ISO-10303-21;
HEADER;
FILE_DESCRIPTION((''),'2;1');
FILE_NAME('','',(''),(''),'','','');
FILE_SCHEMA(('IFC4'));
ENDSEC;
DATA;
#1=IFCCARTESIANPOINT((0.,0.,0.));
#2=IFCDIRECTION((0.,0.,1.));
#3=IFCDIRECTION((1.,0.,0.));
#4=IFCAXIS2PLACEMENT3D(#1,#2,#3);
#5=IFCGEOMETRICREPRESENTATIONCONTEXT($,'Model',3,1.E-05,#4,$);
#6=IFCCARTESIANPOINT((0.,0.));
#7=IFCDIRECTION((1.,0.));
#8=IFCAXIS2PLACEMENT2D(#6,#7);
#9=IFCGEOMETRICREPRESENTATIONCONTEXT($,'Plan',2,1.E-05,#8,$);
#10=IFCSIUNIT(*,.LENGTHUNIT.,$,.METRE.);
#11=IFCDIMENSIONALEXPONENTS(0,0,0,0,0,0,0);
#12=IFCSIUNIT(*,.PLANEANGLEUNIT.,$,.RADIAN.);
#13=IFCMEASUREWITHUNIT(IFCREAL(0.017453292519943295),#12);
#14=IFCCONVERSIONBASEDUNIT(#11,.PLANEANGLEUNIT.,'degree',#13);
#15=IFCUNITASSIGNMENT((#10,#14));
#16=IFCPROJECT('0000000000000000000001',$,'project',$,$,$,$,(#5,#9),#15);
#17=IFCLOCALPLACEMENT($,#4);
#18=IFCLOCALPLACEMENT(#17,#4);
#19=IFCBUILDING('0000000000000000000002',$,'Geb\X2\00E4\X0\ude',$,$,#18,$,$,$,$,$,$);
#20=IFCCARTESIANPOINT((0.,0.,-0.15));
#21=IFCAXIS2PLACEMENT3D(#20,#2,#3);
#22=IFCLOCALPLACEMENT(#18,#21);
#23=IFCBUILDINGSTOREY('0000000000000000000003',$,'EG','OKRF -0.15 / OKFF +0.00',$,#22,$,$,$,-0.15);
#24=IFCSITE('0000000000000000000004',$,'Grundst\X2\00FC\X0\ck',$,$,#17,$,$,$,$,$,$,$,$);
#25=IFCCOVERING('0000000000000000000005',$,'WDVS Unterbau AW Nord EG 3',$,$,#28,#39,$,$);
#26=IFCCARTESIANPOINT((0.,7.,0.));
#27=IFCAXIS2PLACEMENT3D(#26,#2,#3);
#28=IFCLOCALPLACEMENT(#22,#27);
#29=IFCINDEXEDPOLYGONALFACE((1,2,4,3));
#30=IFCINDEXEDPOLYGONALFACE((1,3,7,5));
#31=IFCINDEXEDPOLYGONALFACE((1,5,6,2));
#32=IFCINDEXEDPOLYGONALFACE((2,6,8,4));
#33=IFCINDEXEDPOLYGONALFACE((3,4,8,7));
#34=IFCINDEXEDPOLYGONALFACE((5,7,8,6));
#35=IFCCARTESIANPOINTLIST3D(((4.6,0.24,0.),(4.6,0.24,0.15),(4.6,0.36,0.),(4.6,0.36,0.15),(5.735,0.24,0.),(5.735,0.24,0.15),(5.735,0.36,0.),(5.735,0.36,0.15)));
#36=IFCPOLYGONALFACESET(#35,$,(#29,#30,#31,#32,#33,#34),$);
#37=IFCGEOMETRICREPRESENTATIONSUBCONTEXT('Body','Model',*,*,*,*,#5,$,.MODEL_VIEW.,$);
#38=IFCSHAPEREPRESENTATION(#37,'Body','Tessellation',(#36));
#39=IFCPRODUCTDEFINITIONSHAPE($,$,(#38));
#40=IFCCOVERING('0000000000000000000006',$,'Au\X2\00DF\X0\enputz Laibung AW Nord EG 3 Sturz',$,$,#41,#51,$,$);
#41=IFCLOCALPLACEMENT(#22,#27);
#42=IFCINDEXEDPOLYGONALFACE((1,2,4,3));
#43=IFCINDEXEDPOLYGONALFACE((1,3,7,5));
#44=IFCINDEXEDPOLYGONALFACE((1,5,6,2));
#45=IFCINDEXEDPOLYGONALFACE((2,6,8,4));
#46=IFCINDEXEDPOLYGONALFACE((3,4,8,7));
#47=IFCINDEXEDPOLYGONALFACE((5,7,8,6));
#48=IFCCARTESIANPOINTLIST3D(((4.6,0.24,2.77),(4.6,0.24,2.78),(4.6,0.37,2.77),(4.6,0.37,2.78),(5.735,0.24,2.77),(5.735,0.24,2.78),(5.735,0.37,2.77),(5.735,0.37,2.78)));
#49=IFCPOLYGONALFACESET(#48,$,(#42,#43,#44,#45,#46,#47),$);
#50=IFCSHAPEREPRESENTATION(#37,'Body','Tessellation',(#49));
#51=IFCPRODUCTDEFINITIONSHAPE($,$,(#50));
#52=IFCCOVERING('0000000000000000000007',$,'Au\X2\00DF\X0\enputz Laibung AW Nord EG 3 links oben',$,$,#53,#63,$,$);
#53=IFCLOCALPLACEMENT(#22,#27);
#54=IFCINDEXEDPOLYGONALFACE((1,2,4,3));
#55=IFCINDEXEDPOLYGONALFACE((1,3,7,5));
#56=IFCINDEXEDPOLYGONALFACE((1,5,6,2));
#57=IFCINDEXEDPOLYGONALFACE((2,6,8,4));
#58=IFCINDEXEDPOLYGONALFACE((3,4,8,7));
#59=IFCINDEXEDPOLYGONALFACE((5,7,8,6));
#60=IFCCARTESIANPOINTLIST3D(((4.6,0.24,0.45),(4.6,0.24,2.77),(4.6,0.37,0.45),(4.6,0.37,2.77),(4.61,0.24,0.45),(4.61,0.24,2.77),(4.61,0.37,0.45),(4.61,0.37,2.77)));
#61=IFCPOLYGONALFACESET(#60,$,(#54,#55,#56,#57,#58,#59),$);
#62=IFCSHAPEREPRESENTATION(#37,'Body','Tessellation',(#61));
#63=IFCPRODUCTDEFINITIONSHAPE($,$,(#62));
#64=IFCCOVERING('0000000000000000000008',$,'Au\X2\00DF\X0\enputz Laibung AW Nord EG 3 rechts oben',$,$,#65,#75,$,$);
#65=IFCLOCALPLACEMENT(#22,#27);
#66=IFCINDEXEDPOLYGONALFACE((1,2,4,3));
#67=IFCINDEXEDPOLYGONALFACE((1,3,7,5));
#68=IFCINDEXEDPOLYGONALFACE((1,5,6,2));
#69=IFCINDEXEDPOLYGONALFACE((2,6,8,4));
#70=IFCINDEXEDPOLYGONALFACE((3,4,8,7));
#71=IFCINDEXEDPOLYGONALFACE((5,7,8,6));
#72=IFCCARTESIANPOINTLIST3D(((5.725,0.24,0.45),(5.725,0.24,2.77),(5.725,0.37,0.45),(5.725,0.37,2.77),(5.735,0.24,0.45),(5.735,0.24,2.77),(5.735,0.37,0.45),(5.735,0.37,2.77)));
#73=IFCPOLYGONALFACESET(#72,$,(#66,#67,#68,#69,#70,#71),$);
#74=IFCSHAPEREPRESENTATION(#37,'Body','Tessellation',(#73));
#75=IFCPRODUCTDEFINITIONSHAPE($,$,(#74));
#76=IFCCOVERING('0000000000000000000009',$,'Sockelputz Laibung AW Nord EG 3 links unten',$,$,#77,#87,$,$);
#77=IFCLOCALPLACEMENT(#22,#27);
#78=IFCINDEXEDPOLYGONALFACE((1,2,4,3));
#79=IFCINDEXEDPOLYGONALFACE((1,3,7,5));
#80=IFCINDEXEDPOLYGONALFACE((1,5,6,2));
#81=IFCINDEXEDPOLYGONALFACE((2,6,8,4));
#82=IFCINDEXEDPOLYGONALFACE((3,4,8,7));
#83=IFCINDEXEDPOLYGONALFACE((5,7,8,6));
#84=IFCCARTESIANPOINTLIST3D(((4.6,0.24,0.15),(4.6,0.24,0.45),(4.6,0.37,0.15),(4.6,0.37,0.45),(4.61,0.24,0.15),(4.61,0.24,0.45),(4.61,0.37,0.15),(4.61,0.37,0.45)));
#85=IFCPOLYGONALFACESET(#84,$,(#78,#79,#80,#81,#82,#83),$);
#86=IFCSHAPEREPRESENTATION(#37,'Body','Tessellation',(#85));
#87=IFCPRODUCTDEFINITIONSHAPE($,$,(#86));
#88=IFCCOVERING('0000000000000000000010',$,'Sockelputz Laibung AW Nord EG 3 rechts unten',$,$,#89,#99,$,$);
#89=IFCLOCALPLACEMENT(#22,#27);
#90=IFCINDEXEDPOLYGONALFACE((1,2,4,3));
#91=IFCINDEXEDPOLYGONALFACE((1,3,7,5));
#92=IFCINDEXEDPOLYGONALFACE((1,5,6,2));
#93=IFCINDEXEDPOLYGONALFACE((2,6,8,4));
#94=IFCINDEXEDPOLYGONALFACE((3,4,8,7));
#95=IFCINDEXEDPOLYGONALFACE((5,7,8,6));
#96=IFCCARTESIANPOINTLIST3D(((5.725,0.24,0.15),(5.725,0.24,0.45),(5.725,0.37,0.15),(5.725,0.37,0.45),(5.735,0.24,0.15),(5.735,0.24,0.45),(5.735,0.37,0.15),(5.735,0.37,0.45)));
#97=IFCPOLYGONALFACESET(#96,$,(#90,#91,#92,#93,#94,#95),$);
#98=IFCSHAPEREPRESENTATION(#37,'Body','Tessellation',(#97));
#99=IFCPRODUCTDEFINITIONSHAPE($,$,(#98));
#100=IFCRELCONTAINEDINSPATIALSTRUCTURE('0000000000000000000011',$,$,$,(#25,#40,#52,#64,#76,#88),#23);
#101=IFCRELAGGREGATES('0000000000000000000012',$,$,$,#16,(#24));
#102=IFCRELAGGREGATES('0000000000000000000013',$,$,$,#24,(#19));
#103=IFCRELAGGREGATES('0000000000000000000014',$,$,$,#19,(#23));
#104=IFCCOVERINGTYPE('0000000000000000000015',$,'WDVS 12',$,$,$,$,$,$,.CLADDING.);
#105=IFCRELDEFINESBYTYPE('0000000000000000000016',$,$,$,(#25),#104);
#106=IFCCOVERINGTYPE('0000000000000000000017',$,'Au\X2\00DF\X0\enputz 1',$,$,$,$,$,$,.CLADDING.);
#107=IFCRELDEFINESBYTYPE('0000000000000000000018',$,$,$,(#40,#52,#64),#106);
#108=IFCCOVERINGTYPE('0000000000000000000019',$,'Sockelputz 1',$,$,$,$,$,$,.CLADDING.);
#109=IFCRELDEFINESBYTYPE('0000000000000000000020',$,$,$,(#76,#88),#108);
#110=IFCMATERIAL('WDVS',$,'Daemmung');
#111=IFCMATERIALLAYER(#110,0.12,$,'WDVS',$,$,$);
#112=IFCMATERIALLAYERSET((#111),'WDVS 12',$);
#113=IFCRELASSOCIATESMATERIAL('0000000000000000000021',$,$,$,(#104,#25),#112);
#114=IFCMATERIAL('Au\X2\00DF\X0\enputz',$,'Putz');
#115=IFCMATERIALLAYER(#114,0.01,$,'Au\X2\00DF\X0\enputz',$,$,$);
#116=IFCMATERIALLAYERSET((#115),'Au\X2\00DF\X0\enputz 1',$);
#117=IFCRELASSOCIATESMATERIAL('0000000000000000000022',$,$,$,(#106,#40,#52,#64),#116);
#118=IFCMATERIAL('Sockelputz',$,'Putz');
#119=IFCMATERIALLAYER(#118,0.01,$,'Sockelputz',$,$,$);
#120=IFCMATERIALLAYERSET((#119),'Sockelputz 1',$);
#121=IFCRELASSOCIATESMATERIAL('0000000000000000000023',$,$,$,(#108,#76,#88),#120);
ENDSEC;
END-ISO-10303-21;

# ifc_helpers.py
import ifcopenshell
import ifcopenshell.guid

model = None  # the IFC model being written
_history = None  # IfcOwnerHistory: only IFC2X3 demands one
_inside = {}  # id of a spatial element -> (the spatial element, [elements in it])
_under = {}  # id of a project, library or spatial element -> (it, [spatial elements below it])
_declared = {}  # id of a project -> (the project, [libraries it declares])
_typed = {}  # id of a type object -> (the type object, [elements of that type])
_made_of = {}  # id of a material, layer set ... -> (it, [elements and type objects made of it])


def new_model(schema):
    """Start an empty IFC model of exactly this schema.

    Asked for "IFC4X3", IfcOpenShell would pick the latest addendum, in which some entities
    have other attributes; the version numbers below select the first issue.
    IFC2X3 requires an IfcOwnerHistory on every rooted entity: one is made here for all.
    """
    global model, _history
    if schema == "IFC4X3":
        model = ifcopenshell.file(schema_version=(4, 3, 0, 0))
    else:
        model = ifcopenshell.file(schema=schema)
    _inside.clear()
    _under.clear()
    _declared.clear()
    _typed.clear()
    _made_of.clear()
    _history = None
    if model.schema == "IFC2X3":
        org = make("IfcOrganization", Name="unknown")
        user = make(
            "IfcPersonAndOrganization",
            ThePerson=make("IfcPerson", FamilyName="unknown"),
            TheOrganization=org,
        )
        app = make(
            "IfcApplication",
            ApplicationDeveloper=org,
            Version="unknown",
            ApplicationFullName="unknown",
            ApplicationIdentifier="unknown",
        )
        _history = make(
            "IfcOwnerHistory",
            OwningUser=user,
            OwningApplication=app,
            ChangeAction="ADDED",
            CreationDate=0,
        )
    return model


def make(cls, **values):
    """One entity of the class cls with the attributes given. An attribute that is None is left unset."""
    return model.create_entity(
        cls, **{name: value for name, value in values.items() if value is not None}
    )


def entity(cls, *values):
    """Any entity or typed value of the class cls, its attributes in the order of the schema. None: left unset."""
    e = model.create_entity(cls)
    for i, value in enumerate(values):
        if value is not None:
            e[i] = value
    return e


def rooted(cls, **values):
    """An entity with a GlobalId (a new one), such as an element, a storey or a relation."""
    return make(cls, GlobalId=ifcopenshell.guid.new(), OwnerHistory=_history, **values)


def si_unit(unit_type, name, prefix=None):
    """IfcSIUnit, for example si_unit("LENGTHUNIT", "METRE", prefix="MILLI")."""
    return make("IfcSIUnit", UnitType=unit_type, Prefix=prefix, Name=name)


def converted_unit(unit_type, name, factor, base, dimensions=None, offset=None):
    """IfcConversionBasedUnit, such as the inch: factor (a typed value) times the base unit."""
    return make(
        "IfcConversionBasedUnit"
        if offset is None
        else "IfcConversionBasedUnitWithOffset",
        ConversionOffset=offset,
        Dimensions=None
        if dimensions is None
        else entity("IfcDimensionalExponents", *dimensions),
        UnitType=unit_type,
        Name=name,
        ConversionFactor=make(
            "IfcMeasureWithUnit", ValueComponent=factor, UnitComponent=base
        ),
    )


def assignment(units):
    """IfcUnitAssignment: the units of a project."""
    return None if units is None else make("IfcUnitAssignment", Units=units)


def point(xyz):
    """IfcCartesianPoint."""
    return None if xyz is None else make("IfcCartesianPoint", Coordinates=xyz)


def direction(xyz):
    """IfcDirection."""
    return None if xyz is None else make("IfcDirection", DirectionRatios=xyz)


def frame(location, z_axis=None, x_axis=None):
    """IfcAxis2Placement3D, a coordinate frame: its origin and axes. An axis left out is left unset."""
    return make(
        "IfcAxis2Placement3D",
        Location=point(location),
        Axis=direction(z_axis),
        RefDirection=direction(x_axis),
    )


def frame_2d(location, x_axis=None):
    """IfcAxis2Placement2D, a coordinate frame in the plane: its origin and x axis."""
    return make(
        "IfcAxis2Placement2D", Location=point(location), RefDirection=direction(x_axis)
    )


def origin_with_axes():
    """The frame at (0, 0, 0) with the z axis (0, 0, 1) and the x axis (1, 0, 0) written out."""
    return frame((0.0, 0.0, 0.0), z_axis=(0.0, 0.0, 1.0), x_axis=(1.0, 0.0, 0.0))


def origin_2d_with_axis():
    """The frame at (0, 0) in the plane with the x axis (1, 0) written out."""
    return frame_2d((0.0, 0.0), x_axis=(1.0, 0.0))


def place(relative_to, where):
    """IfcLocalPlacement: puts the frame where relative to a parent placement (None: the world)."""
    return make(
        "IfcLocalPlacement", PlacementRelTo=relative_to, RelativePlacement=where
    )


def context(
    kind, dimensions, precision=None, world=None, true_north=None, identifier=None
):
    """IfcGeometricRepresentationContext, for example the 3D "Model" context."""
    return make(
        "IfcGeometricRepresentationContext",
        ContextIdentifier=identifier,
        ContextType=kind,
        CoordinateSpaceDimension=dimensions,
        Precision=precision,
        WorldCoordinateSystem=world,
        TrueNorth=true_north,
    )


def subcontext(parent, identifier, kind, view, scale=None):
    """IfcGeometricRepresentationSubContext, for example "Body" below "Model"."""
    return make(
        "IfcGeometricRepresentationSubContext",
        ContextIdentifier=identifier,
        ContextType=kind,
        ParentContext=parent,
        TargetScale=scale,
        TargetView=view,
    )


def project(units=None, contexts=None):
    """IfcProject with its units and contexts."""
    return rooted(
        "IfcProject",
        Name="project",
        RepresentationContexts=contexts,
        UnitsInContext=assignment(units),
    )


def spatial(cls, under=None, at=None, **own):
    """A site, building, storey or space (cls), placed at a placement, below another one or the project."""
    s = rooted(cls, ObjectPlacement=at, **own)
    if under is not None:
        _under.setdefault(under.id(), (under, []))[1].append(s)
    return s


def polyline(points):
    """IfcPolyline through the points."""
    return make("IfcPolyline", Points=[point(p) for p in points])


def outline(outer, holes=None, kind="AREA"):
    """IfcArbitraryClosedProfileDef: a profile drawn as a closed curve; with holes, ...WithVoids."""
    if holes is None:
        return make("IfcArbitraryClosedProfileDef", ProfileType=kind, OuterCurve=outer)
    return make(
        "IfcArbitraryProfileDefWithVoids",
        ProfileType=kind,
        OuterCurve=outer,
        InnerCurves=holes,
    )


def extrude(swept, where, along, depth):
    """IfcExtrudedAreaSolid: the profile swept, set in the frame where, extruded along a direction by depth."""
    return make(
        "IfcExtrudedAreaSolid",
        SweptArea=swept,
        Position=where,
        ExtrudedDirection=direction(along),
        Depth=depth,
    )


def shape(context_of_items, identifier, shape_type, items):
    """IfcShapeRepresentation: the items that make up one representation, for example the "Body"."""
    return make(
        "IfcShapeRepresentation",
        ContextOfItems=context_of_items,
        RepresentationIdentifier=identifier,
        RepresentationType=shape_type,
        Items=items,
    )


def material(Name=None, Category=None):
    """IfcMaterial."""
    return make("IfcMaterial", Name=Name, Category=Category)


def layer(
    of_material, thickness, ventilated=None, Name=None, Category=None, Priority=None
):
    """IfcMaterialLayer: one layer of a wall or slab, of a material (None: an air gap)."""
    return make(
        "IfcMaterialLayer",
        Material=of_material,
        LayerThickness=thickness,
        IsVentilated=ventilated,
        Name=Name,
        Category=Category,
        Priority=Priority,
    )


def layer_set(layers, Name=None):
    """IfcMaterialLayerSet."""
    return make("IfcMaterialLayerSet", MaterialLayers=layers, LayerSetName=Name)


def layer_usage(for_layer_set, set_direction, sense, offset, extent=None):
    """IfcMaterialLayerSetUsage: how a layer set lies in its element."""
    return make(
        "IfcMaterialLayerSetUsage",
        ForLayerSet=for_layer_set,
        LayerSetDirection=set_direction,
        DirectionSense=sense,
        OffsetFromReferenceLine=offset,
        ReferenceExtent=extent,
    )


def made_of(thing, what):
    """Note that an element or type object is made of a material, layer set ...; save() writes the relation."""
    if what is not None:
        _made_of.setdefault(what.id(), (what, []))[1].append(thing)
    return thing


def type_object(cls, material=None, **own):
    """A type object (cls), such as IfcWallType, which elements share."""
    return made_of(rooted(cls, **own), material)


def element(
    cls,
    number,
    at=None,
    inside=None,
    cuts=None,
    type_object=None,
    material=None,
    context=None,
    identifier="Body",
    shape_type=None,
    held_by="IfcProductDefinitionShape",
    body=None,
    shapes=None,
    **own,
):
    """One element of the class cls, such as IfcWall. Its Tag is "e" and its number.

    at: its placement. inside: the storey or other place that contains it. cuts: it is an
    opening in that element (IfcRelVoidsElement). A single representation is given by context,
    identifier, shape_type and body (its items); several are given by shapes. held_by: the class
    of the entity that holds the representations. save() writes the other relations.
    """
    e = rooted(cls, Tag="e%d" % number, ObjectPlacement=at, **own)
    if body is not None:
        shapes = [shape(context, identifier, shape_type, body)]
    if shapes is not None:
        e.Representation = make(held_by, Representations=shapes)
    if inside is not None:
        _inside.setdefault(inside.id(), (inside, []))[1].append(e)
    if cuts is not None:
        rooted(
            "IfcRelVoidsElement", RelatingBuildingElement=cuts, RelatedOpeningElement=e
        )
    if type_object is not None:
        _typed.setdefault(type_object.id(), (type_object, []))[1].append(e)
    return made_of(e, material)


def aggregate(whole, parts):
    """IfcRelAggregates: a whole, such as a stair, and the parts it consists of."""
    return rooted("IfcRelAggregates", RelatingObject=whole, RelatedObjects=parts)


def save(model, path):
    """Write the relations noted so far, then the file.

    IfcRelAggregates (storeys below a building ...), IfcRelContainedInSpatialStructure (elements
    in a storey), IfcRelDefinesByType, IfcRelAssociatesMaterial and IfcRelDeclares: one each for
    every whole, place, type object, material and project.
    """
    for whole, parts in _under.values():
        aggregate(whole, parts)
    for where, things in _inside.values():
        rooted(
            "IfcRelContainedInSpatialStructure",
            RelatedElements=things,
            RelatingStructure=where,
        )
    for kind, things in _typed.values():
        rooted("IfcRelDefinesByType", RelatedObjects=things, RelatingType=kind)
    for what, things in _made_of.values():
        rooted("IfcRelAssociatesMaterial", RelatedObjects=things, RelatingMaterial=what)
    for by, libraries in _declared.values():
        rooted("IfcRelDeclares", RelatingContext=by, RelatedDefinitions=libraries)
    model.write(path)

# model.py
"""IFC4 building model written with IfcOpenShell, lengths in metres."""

from ifc_helpers import new_model, entity, si_unit, converted_unit, frame, origin_with_axes, origin_2d_with_axis, place, context, subcontext, project, spatial, polyline, outline, extrude, material, layer, layer_set, layer_usage, type_object, element, save


model = new_model("IFC4")

# Units and contexts
model_context = context("Model", 3, precision=1e-05, world=origin_with_axes())
plan_context = context("Plan", 2, precision=1e-05, world=origin_2d_with_axis())
body_context_1 = subcontext(model_context, "Body", "Model", "MODEL_VIEW")
ifc_project = project(units=[si_unit("LENGTHUNIT", "METRE"), converted_unit("PLANEANGLEUNIT", "degree", entity("IfcReal", 0.017453292519943295), si_unit("PLANEANGLEUNIT", "RADIAN"), dimensions=[0, 0, 0, 0, 0, 0, 0])], contexts=[model_context, plan_context])

# Site, building, storey
site_placement = place(None, origin_with_axes())
site = spatial("IfcSite", under=ifc_project, at=site_placement, Name="Grundstück")
building_placement = place(site_placement, origin_with_axes())
building = spatial("IfcBuilding", under=site, at=building_placement, Name="Gebäude")
storey_placement = place(building_placement, frame((0.0, 0.0, -0.15), z_axis=(0.0, 0.0, 1.0), x_axis=(1.0, 0.0, 0.0)))
storey = spatial("IfcBuildingStorey", under=building, at=storey_placement, Name="EG", Description="OKRF -0.15 / OKFF +0.00", Elevation=-0.15)

# Covering
ifc_material_1 = material(Name="WDVS", Category="Daemmung")
ifc_layer_1 = layer(ifc_material_1, 0.12, Name="WDVS")
ifc_layer_set_1 = layer_set([ifc_layer_1], Name="WDVS 12")
ifc_layer_usage_1 = layer_usage(ifc_layer_set_1, "AXIS2", "POSITIVE", 0.24)
covering_type_1 = type_object("IfcCoveringType", Name="WDVS 12", PredefinedType="CLADDING", material=ifc_layer_set_1)
covering_1_placement = place(storey_placement, frame((0.0, 7.0, 0.0), z_axis=(0.0, 0.0, 1.0), x_axis=(1.0, 0.0, 0.0)))
element("IfcCovering", 1, at=covering_1_placement, inside=storey, type_object=covering_type_1, material=ifc_layer_usage_1, Name="WDVS Unterbau AW Nord EG 3", context=body_context_1, shape_type="SweptSolid", body=[
    extrude(outline(polyline([(0.24, 0.0), (0.36, 0.0), (0.36, 0.15), (0.24, 0.15), (0.24, 0.0)])), frame((4.6, 0.0, 0.0), z_axis=(1.0, 0.0, 0.0), x_axis=(0.0, 1.0, 0.0)), (0.0, 0.0, 1.0), 1.135),
])

# Coverings
ifc_material_2 = material(Name="Außenputz", Category="Putz")
ifc_layer_2 = layer(ifc_material_2, 0.01, Name="Außenputz")
ifc_layer_set_2 = layer_set([ifc_layer_2], Name="Außenputz 1")
ifc_layer_usage_2 = layer_usage(ifc_layer_set_2, "AXIS3", "POSITIVE", 2.77)
covering_type_2 = type_object("IfcCoveringType", Name="Außenputz 1", PredefinedType="CLADDING", material=ifc_layer_set_2)
covering_2_placement = place(storey_placement, frame((0.0, 7.0, 0.0), z_axis=(0.0, 0.0, 1.0), x_axis=(1.0, 0.0, 0.0)))
element("IfcCovering", 2, at=covering_2_placement, inside=storey, type_object=covering_type_2, material=ifc_layer_usage_2, Name="Außenputz Laibung AW Nord EG 3 Sturz", context=body_context_1, shape_type="SweptSolid", body=[
    extrude(outline(polyline([(0.24, 2.77), (0.37, 2.77), (0.37, 2.78), (0.24, 2.78), (0.24, 2.77)])), frame((4.6, 0.0, 0.0), z_axis=(1.0, 0.0, 0.0), x_axis=(0.0, 1.0, 0.0)), (0.0, 0.0, 1.0), 1.135),
])
ifc_layer_usage_3 = layer_usage(ifc_layer_set_2, "AXIS1", "POSITIVE", 4.6)
covering_3_placement = place(storey_placement, frame((0.0, 7.0, 0.0), z_axis=(0.0, 0.0, 1.0), x_axis=(1.0, 0.0, 0.0)))
element("IfcCovering", 3, at=covering_3_placement, inside=storey, type_object=covering_type_2, material=ifc_layer_usage_3, Name="Außenputz Laibung AW Nord EG 3 links oben", context=body_context_1, shape_type="SweptSolid", body=[
    extrude(outline(polyline([(0.24, 0.45), (0.37, 0.45), (0.37, 2.77), (0.24, 2.77), (0.24, 0.45)])), frame((4.6, 0.0, 0.0), z_axis=(1.0, 0.0, 0.0), x_axis=(0.0, 1.0, 0.0)), (0.0, 0.0, 1.0), 0.01),
])
ifc_layer_usage_4 = layer_usage(ifc_layer_set_2, "AXIS1", "POSITIVE", 5.725)
covering_4_placement = place(storey_placement, frame((0.0, 7.0, 0.0), z_axis=(0.0, 0.0, 1.0), x_axis=(1.0, 0.0, 0.0)))
element("IfcCovering", 4, at=covering_4_placement, inside=storey, type_object=covering_type_2, material=ifc_layer_usage_4, Name="Außenputz Laibung AW Nord EG 3 rechts oben", context=body_context_1, shape_type="SweptSolid", body=[
    extrude(outline(polyline([(0.24, 0.45), (0.37, 0.45), (0.37, 2.77), (0.24, 2.77), (0.24, 0.45)])), frame((5.725, 0.0, 0.0), z_axis=(1.0, 0.0, 0.0), x_axis=(0.0, 1.0, 0.0)), (0.0, 0.0, 1.0), 0.01),
])
ifc_material_3 = material(Name="Sockelputz", Category="Putz")
ifc_layer_3 = layer(ifc_material_3, 0.01, Name="Sockelputz")
ifc_layer_set_3 = layer_set([ifc_layer_3], Name="Sockelputz 1")
ifc_layer_usage_5 = layer_usage(ifc_layer_set_3, "AXIS1", "POSITIVE", 4.6)
covering_type_3 = type_object("IfcCoveringType", Name="Sockelputz 1", PredefinedType="CLADDING", material=ifc_layer_set_3)
covering_5_placement = place(storey_placement, frame((0.0, 7.0, 0.0), z_axis=(0.0, 0.0, 1.0), x_axis=(1.0, 0.0, 0.0)))
element("IfcCovering", 5, at=covering_5_placement, inside=storey, type_object=covering_type_3, material=ifc_layer_usage_5, Name="Sockelputz Laibung AW Nord EG 3 links unten", context=body_context_1, shape_type="SweptSolid", body=[
    extrude(outline(polyline([(0.24, 0.15), (0.37, 0.15), (0.37, 0.45), (0.24, 0.45), (0.24, 0.15)])), frame((4.6, 0.0, 0.0), z_axis=(1.0, 0.0, 0.0), x_axis=(0.0, 1.0, 0.0)), (0.0, 0.0, 1.0), 0.01),
])
ifc_layer_usage_6 = layer_usage(ifc_layer_set_3, "AXIS1", "POSITIVE", 5.725)
covering_6_placement = place(storey_placement, frame((0.0, 7.0, 0.0), z_axis=(0.0, 0.0, 1.0), x_axis=(1.0, 0.0, 0.0)))
element("IfcCovering", 6, at=covering_6_placement, inside=storey, type_object=covering_type_3, material=ifc_layer_usage_6, Name="Sockelputz Laibung AW Nord EG 3 rechts unten", context=body_context_1, shape_type="SweptSolid", body=[
    extrude(outline(polyline([(0.24, 0.15), (0.37, 0.15), (0.37, 0.45), (0.24, 0.45), (0.24, 0.15)])), frame((5.725, 0.0, 0.0), z_axis=(1.0, 0.0, 0.0), x_axis=(0.0, 1.0, 0.0)), (0.0, 0.0, 1.0), 0.01),
])

save(model, "model.ifc")
